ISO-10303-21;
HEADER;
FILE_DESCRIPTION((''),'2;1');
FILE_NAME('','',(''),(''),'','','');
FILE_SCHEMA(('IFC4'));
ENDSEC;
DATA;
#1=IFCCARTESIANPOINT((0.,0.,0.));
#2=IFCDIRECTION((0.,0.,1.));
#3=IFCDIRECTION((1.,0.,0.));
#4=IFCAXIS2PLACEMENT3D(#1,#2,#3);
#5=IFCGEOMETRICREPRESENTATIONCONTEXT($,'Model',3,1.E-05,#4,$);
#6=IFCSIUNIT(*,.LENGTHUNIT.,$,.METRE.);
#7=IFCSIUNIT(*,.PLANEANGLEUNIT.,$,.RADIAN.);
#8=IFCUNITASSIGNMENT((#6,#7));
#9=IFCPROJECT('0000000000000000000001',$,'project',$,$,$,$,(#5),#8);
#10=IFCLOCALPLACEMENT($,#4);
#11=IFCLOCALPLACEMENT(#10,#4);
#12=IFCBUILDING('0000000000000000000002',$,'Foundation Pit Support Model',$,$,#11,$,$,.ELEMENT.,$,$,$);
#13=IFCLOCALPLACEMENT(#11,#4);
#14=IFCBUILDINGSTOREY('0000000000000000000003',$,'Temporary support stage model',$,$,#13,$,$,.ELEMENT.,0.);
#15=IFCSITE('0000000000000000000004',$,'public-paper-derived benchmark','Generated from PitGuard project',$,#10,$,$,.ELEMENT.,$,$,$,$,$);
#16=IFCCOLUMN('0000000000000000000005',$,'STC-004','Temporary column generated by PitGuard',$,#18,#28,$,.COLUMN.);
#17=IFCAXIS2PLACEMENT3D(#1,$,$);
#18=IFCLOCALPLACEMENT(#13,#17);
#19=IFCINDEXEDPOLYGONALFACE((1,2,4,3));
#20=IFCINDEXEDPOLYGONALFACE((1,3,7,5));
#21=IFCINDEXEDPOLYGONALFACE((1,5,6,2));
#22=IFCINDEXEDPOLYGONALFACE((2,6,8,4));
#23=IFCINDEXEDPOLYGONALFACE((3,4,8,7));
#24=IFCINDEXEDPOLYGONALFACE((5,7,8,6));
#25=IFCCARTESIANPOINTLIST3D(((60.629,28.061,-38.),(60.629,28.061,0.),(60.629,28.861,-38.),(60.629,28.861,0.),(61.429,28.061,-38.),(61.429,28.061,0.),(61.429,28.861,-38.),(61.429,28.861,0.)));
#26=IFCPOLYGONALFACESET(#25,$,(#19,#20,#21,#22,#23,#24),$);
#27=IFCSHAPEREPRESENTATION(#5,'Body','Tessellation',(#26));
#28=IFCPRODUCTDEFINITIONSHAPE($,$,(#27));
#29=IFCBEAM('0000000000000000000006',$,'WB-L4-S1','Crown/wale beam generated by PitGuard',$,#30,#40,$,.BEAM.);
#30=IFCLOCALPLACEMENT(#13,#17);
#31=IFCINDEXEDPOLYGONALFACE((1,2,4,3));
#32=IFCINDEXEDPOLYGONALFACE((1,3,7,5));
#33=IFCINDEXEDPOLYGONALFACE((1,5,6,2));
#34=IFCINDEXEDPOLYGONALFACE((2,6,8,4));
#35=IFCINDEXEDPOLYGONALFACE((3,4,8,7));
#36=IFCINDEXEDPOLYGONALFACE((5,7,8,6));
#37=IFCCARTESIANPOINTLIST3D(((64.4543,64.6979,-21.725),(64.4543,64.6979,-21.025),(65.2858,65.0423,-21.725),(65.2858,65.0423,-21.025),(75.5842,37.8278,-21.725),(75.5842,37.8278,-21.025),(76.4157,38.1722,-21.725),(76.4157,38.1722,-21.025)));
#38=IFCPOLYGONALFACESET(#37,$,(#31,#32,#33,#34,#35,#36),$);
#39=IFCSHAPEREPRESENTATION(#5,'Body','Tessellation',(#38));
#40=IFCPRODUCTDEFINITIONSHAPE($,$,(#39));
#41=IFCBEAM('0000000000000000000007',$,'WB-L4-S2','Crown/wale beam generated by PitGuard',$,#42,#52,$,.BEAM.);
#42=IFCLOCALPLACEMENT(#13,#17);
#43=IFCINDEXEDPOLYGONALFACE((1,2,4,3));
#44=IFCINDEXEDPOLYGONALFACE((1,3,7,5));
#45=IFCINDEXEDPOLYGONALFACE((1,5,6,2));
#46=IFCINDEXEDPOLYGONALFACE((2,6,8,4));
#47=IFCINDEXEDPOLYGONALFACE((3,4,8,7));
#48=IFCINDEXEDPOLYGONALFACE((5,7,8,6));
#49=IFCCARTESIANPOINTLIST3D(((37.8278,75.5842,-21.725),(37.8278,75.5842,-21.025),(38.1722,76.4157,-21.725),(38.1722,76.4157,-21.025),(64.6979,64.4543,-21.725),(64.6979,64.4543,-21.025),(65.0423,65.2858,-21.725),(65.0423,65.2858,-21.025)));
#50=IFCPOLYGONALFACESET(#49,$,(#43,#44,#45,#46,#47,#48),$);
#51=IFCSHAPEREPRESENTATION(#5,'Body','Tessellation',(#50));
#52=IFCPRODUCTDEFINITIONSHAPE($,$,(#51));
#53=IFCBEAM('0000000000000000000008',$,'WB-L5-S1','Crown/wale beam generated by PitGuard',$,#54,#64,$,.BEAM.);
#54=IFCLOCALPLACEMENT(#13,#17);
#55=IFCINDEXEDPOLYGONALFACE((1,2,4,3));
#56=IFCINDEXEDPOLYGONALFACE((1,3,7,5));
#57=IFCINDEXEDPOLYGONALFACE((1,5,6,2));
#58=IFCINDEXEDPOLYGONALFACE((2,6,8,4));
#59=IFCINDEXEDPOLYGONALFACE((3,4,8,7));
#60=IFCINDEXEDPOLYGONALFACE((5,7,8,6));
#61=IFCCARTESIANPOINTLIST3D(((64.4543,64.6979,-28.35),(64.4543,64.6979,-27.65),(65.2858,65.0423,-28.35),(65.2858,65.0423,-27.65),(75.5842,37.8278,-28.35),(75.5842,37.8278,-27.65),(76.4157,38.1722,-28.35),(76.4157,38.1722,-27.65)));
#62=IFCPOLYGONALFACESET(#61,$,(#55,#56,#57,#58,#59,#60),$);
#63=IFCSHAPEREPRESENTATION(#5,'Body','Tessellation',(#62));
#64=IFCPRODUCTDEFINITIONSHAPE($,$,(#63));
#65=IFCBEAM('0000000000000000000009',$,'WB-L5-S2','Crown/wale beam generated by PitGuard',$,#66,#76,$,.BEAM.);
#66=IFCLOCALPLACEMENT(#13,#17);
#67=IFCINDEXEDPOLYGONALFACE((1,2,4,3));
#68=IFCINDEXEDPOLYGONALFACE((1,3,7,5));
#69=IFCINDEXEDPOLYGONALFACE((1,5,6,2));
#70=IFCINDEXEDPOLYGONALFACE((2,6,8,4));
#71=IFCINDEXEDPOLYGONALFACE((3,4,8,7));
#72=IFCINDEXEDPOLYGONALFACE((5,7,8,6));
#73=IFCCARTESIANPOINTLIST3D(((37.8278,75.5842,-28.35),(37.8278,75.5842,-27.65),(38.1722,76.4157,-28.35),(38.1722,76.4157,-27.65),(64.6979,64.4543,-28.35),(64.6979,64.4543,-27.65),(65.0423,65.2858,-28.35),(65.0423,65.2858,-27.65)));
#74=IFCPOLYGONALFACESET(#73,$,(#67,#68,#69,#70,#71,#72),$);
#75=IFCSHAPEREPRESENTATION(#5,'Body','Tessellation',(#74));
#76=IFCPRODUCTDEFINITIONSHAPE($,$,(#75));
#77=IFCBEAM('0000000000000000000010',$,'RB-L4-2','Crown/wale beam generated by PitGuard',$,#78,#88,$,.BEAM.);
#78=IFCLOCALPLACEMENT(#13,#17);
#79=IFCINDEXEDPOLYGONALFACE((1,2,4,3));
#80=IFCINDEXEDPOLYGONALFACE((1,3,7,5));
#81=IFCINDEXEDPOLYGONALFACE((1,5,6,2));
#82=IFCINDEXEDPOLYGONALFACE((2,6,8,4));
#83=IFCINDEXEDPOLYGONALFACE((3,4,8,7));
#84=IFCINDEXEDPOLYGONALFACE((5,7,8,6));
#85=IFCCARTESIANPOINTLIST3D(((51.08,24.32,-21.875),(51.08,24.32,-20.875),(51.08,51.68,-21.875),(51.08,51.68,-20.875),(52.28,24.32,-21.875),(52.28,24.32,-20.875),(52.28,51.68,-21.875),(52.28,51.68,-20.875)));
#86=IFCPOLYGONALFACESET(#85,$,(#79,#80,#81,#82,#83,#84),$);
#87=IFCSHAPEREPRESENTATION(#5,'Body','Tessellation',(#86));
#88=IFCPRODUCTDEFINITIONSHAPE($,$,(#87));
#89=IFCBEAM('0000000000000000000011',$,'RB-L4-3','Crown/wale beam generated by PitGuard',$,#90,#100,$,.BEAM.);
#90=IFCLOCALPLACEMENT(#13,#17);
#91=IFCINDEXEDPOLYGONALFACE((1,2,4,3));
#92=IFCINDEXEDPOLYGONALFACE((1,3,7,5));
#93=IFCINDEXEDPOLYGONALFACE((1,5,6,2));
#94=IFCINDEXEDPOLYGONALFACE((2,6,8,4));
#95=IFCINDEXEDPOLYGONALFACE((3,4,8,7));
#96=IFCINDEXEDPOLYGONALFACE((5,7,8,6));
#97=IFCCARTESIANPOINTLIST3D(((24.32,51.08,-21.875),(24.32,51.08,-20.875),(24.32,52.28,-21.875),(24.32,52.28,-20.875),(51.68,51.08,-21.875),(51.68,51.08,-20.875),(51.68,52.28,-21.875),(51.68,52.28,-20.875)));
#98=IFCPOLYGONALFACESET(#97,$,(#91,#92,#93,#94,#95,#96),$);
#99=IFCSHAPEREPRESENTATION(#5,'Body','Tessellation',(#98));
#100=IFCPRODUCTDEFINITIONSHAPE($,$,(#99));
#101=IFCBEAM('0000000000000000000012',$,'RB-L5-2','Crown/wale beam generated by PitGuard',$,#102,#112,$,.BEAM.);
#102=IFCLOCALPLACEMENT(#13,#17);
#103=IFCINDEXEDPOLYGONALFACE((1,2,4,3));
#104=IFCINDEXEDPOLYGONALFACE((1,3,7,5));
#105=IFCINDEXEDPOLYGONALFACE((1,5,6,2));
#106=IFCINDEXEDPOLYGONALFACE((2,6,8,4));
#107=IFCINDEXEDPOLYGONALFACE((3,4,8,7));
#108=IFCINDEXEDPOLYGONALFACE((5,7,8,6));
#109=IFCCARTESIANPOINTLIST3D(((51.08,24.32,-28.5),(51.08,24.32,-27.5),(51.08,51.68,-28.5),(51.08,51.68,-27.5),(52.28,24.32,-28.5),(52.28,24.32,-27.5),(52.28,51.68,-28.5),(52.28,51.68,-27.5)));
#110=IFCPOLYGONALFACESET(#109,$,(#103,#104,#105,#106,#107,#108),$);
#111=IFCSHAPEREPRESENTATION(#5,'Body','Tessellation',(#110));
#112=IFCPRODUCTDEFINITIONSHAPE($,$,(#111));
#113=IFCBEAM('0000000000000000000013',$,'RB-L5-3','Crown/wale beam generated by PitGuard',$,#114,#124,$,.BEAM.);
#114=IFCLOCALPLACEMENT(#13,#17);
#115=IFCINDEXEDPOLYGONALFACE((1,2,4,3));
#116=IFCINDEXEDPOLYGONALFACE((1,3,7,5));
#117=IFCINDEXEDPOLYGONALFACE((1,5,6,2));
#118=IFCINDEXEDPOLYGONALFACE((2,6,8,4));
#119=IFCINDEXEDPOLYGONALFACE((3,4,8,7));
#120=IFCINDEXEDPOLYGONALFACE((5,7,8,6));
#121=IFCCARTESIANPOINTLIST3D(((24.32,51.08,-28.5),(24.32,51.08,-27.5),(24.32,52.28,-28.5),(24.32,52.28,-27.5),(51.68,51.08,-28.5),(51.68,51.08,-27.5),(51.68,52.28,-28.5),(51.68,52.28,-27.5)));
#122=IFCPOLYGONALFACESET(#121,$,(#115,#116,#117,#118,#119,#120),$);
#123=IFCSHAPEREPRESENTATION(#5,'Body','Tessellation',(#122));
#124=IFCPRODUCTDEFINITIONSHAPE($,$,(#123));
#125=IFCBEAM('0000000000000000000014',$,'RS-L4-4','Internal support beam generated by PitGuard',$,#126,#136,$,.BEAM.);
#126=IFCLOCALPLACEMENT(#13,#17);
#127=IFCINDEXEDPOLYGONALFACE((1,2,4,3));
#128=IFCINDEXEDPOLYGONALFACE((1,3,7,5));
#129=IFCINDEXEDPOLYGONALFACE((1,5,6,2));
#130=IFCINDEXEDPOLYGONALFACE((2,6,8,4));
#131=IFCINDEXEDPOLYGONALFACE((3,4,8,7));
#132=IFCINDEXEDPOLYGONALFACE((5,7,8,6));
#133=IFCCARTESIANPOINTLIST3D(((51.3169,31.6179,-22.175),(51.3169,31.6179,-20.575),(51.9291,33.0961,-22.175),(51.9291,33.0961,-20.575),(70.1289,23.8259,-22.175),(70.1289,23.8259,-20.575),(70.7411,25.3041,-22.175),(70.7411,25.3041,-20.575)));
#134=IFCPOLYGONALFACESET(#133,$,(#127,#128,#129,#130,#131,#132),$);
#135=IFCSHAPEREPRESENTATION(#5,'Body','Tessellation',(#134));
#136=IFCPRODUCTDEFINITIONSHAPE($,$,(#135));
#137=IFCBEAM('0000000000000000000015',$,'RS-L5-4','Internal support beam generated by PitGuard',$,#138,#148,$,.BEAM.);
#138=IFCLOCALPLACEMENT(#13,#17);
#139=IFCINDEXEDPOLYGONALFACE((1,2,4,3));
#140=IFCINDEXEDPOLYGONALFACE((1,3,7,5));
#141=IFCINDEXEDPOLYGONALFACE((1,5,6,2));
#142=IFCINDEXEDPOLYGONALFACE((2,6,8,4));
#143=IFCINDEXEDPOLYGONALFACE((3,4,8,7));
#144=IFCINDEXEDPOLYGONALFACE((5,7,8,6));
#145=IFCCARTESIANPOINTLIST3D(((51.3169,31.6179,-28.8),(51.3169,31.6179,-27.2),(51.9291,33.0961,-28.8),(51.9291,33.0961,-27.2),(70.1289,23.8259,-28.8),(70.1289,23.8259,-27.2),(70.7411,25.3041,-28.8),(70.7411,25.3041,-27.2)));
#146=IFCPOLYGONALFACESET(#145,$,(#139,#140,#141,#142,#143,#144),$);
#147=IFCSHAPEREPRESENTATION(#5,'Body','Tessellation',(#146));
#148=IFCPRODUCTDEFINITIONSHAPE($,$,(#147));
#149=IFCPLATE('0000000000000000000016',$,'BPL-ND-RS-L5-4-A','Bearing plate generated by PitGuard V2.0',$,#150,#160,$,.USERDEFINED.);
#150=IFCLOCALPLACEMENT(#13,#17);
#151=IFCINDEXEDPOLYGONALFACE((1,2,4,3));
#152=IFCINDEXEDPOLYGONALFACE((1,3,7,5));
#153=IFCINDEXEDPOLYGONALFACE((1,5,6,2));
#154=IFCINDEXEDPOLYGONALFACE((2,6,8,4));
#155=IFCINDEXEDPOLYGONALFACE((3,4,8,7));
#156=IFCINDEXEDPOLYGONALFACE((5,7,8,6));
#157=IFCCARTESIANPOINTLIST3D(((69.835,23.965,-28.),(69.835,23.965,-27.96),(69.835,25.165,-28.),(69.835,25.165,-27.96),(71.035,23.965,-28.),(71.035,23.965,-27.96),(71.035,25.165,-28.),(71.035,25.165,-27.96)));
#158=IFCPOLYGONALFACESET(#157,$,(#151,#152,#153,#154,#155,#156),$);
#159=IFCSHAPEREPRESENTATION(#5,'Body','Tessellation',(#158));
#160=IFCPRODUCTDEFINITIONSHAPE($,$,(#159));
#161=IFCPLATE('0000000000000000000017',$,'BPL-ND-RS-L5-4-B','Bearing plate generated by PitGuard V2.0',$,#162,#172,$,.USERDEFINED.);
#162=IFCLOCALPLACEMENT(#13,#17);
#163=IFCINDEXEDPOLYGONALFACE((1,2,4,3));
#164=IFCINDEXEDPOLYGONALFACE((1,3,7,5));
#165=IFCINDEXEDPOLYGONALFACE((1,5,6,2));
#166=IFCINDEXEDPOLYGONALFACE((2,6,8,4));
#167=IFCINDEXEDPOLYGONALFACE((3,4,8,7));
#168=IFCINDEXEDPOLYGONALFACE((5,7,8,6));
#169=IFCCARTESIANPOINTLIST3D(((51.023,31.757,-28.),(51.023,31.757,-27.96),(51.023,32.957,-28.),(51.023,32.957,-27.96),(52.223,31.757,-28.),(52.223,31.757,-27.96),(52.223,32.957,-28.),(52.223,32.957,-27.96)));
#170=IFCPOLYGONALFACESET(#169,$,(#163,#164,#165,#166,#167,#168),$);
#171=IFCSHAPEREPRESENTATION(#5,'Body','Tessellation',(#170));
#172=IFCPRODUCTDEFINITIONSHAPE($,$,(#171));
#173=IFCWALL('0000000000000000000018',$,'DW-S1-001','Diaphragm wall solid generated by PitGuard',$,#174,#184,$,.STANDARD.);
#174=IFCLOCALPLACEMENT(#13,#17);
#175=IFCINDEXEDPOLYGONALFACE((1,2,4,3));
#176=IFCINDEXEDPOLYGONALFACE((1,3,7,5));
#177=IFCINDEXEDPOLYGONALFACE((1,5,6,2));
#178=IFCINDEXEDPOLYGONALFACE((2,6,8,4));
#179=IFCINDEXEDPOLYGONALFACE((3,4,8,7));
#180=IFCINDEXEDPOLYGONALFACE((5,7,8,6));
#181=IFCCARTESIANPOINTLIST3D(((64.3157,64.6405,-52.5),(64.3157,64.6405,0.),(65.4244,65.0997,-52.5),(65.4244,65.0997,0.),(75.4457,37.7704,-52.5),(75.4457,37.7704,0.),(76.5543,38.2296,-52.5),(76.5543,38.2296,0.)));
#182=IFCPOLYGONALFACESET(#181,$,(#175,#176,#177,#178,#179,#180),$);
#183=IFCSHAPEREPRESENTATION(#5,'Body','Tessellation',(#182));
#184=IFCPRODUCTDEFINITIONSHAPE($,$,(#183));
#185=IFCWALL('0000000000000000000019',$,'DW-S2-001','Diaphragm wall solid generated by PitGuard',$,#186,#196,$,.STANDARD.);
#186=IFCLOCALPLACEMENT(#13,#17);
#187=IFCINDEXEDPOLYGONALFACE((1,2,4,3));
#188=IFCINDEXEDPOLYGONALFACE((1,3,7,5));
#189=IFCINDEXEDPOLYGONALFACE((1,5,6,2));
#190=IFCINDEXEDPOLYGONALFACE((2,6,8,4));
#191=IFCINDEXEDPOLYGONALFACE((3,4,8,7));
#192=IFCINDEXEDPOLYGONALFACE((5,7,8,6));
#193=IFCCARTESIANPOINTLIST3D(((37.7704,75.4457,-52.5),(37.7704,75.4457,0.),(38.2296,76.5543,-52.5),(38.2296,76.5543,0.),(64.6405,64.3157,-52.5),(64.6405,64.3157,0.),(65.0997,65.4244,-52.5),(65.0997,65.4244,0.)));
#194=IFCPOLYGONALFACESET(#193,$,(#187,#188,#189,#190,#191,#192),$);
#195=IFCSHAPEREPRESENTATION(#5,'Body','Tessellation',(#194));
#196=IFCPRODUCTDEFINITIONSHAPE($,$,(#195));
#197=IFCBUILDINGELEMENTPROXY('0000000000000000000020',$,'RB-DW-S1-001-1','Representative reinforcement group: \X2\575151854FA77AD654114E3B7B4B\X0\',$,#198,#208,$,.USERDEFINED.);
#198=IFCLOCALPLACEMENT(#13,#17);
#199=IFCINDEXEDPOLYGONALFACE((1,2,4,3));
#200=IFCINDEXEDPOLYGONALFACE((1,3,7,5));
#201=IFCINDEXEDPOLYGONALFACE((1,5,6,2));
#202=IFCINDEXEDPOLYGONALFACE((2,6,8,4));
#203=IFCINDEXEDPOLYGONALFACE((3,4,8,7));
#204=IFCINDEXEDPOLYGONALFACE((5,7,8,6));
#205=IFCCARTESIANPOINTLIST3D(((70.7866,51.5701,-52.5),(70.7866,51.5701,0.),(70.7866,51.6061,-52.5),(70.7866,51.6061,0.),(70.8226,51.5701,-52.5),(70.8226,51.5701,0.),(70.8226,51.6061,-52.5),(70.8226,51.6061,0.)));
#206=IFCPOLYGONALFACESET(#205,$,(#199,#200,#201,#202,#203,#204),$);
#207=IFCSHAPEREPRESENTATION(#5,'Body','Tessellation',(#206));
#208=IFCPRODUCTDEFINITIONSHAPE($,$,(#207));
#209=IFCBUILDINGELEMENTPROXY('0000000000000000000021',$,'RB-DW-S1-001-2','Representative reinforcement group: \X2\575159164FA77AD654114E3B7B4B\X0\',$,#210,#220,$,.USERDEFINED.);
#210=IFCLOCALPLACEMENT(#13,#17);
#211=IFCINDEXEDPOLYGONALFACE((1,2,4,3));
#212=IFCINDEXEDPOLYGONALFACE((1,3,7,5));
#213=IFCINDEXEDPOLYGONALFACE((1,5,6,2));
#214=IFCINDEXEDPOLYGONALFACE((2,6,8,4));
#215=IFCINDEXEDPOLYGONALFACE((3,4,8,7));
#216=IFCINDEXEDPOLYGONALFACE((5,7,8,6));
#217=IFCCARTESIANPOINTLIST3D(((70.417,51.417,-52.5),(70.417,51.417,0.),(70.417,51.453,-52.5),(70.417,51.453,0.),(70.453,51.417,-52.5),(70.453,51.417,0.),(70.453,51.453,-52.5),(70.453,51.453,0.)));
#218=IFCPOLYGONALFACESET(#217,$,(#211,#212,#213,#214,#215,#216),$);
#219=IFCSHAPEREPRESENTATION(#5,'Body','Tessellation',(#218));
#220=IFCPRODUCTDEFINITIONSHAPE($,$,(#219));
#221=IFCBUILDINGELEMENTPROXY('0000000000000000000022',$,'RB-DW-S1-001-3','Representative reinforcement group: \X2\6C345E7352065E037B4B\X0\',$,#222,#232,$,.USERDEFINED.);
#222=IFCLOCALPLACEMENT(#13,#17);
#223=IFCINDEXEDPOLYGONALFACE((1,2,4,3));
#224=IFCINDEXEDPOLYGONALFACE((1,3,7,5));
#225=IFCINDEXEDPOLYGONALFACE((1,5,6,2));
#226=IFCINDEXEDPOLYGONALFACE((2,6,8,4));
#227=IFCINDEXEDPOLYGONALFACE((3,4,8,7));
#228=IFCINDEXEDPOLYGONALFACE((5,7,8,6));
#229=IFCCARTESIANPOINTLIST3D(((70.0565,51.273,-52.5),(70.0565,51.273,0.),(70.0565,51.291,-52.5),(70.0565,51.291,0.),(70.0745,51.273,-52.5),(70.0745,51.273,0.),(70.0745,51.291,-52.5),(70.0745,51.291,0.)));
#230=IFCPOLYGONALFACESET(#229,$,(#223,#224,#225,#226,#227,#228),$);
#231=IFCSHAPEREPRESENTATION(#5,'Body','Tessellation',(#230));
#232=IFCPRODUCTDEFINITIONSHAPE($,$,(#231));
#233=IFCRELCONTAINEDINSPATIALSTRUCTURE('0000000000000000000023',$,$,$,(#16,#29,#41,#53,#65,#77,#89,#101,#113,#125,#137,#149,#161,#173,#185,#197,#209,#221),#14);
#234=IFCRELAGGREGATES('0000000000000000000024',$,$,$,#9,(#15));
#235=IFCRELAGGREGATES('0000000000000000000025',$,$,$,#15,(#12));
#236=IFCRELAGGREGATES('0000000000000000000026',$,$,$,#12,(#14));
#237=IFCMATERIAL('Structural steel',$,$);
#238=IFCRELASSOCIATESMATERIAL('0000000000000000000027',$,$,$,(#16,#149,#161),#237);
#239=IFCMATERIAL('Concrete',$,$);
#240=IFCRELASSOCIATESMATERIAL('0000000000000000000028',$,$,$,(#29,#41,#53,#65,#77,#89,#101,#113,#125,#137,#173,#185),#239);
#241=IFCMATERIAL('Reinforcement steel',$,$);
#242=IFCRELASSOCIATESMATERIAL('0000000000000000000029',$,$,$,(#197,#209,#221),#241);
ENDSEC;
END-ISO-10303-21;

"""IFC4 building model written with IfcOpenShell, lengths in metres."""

from ifc_helpers import new_model, si_unit, frame, origin_with_axes, origin_2d, place, context, project, spatial, rectangle, extrude, material, element, save


model = new_model("IFC4")

# Units and contexts
model_context = context("Model", 3, precision=1e-05, world=origin_with_axes())
ifc_project = project(units=[si_unit("LENGTHUNIT", "METRE"), si_unit("PLANEANGLEUNIT", "RADIAN")], contexts=[model_context])

# Site, building, storey
site_placement = place(None, origin_with_axes())
site = spatial("IfcSite", under=ifc_project, at=site_placement, Name="public-paper-derived benchmark", Description="Generated from PitGuard project", CompositionType="ELEMENT")
building_placement = place(site_placement, origin_with_axes())
building = spatial("IfcBuilding", under=site, at=building_placement, Name="Foundation Pit Support Model", CompositionType="ELEMENT")
storey_placement = place(building_placement, origin_with_axes())
storey = spatial("IfcBuildingStorey", under=building, at=storey_placement, Name="Temporary support stage model", CompositionType="ELEMENT", Elevation=0.0)

# Column
ifc_material_1 = material(Name="Structural steel")
column_placement = place(storey_placement, frame((61.029, 28.461, -38.0), z_axis=(0.0, 0.0, 1.0), x_axis=(1.0, 0.0, 0.0)))
element("IfcColumn", 1, at=column_placement, inside=storey, material=ifc_material_1, Name="STC-004", Description="Temporary column generated by PitGuard", PredefinedType="COLUMN", context=model_context, shape_type="SweptSolid", body=[
    extrude(rectangle(XDim=0.8, YDim=0.8, at=origin_2d()), origin_with_axes(), (0.0, 0.0, 1.0), 38.0),
])

# Beams
ifc_material_2 = material(Name="Concrete")
for number, where, z_axis, x_axis, name in (
    (2, (70.435, 51.435, -21.725), (0.0, 0.0, 1.0), (-0.382683, 0.92388, 0.0), "WB-L4-S1"),
    (3, (51.435, 70.435, -21.725), (0.0, 0.0, 1.0), (-0.92388, 0.382683, 0.0), "WB-L4-S2"),
    (4, (70.435, 51.435, -28.35), (0.0, 0.0, 1.0), (-0.382683, 0.92388, 0.0), "WB-L5-S1"),
    (5, (51.435, 70.435, -28.35), (0.0, 0.0, 1.0), (-0.92388, 0.382683, 0.0), "WB-L5-S2"),
):
    element("IfcBeam", number, at=place(storey_placement, frame(where, z_axis=z_axis, x_axis=x_axis)), inside=storey, material=ifc_material_2, Name=name, Description="Crown/wale beam generated by PitGuard", PredefinedType="BEAM", context=model_context, shape_type="SweptSolid", body=[
        extrude(rectangle(XDim=29.0839, YDim=0.9, at=origin_2d()), origin_with_axes(), (0.0, 0.0, 1.0), 0.7),
    ])
for number, where, z_axis, x_axis, name in (
    (6, (51.68, 38.0, -21.875), (0.0, 0.0, 1.0), (0.0, 1.0, 0.0), "RB-L4-2"),
    (7, (38.0, 51.68, -21.875), (0.0, 0.0, 1.0), (-1.0, 0.0, 0.0), "RB-L4-3"),
    (8, (51.68, 38.0, -28.5), (0.0, 0.0, 1.0), (0.0, 1.0, 0.0), "RB-L5-2"),
    (9, (38.0, 51.68, -28.5), (0.0, 0.0, 1.0), (-1.0, 0.0, 0.0), "RB-L5-3"),
):
    element("IfcBeam", number, at=place(storey_placement, frame(where, z_axis=z_axis, x_axis=x_axis)), inside=storey, material=ifc_material_2, Name=name, Description="Crown/wale beam generated by PitGuard", PredefinedType="BEAM", context=model_context, shape_type="SweptSolid", body=[
        extrude(rectangle(XDim=27.36, YDim=1.2, at=origin_2d()), origin_with_axes(), (0.0, 0.0, 1.0), 1.0),
    ])
for number, where, z_axis, x_axis, name in (
    (10, (61.029, 28.461, -22.175), (0.0, 0.0, 1.0), (-0.923883, 0.382676, 0.0), "RS-L4-4"),
    (11, (61.029, 28.461, -28.8), (0.0, 0.0, 1.0), (-0.923883, 0.382676, 0.0), "RS-L5-4"),
):
    element("IfcBeam", number, at=place(storey_placement, frame(where, z_axis=z_axis, x_axis=x_axis)), inside=storey, material=ifc_material_2, Name=name, Description="Internal support beam generated by PitGuard", PredefinedType="BEAM", context=model_context, shape_type="SweptSolid", body=[
        extrude(rectangle(XDim=20.3619, YDim=1.6, at=origin_2d()), origin_with_axes(), (0.0, 0.0, 1.0), 1.6),
    ])

# Plates
for number, where, z_axis, x_axis, name in (
    (12, (70.435, 24.565, -28.0), (0.0, 0.0, 1.0), (1.0, 0.0, 0.0), "BPL-ND-RS-L5-4-A"),
    (13, (51.623, 32.357, -28.0), (0.0, 0.0, 1.0), (1.0, 0.0, 0.0), "BPL-ND-RS-L5-4-B"),
):
    element("IfcPlate", number, at=place(storey_placement, frame(where, z_axis=z_axis, x_axis=x_axis)), inside=storey, material=ifc_material_1, Name=name, Description="Bearing plate generated by PitGuard V2.0", PredefinedType="USERDEFINED", context=model_context, shape_type="SweptSolid", body=[
        extrude(rectangle(XDim=1.2, YDim=1.2, at=origin_2d()), origin_with_axes(), (0.0, 0.0, 1.0), 0.04),
    ])

# Walls
for number, where, z_axis, x_axis, name in (
    (14, (70.435, 51.435, -52.5), (0.0, 0.0, 1.0), (-0.382683, 0.92388, 0.0), "DW-S1-001"),
    (15, (51.435, 70.435, -52.5), (0.0, 0.0, 1.0), (-0.92388, 0.382683, 0.0), "DW-S2-001"),
):
    element("IfcWall", number, at=place(storey_placement, frame(where, z_axis=z_axis, x_axis=x_axis)), inside=storey, material=ifc_material_2, Name=name, Description="Diaphragm wall solid generated by PitGuard", PredefinedType="STANDARD", context=model_context, shape_type="SweptSolid", body=[
        extrude(rectangle(XDim=29.0839, YDim=1.2, at=origin_2d()), origin_with_axes(), (0.0, 0.0, 1.0), 52.5),
    ])

# Building element proxies
ifc_material_3 = material(Name="Reinforcement steel")
for number, where, z_axis, x_axis, name, description in (
    (16, (70.8046, 51.5881, -52.5), (0.0, 0.0, 1.0), (1.0, 0.0, 0.0), "RB-DW-S1-001-1", "Representative reinforcement group: 坑内侧竖向主筋"),
    (17, (70.435, 51.435, -52.5), (0.0, 0.0, 1.0), (1.0, 0.0, 0.0), "RB-DW-S1-001-2", "Representative reinforcement group: 坑外侧竖向主筋"),
):
    element("IfcBuildingElementProxy", number, at=place(storey_placement, frame(where, z_axis=z_axis, x_axis=x_axis)), inside=storey, material=ifc_material_3, Name=name, Description=description, PredefinedType="USERDEFINED", context=model_context, shape_type="SweptSolid", body=[
        extrude(rectangle(XDim=0.036, YDim=0.036, at=origin_2d()), origin_with_axes(), (0.0, 0.0, 1.0), 52.5),
    ])
proxy_1_placement = place(storey_placement, frame((70.0655, 51.282, -52.5), z_axis=(0.0, 0.0, 1.0), x_axis=(1.0, 0.0, 0.0)))
element("IfcBuildingElementProxy", 18, at=proxy_1_placement, inside=storey, material=ifc_material_3, Name="RB-DW-S1-001-3", Description="Representative reinforcement group: 水平分布筋", PredefinedType="USERDEFINED", context=model_context, shape_type="SweptSolid", body=[
    extrude(rectangle(XDim=0.018, YDim=0.018, at=origin_2d()), origin_with_axes(), (0.0, 0.0, 1.0), 52.5),
])

save(model, "model.ifc")
